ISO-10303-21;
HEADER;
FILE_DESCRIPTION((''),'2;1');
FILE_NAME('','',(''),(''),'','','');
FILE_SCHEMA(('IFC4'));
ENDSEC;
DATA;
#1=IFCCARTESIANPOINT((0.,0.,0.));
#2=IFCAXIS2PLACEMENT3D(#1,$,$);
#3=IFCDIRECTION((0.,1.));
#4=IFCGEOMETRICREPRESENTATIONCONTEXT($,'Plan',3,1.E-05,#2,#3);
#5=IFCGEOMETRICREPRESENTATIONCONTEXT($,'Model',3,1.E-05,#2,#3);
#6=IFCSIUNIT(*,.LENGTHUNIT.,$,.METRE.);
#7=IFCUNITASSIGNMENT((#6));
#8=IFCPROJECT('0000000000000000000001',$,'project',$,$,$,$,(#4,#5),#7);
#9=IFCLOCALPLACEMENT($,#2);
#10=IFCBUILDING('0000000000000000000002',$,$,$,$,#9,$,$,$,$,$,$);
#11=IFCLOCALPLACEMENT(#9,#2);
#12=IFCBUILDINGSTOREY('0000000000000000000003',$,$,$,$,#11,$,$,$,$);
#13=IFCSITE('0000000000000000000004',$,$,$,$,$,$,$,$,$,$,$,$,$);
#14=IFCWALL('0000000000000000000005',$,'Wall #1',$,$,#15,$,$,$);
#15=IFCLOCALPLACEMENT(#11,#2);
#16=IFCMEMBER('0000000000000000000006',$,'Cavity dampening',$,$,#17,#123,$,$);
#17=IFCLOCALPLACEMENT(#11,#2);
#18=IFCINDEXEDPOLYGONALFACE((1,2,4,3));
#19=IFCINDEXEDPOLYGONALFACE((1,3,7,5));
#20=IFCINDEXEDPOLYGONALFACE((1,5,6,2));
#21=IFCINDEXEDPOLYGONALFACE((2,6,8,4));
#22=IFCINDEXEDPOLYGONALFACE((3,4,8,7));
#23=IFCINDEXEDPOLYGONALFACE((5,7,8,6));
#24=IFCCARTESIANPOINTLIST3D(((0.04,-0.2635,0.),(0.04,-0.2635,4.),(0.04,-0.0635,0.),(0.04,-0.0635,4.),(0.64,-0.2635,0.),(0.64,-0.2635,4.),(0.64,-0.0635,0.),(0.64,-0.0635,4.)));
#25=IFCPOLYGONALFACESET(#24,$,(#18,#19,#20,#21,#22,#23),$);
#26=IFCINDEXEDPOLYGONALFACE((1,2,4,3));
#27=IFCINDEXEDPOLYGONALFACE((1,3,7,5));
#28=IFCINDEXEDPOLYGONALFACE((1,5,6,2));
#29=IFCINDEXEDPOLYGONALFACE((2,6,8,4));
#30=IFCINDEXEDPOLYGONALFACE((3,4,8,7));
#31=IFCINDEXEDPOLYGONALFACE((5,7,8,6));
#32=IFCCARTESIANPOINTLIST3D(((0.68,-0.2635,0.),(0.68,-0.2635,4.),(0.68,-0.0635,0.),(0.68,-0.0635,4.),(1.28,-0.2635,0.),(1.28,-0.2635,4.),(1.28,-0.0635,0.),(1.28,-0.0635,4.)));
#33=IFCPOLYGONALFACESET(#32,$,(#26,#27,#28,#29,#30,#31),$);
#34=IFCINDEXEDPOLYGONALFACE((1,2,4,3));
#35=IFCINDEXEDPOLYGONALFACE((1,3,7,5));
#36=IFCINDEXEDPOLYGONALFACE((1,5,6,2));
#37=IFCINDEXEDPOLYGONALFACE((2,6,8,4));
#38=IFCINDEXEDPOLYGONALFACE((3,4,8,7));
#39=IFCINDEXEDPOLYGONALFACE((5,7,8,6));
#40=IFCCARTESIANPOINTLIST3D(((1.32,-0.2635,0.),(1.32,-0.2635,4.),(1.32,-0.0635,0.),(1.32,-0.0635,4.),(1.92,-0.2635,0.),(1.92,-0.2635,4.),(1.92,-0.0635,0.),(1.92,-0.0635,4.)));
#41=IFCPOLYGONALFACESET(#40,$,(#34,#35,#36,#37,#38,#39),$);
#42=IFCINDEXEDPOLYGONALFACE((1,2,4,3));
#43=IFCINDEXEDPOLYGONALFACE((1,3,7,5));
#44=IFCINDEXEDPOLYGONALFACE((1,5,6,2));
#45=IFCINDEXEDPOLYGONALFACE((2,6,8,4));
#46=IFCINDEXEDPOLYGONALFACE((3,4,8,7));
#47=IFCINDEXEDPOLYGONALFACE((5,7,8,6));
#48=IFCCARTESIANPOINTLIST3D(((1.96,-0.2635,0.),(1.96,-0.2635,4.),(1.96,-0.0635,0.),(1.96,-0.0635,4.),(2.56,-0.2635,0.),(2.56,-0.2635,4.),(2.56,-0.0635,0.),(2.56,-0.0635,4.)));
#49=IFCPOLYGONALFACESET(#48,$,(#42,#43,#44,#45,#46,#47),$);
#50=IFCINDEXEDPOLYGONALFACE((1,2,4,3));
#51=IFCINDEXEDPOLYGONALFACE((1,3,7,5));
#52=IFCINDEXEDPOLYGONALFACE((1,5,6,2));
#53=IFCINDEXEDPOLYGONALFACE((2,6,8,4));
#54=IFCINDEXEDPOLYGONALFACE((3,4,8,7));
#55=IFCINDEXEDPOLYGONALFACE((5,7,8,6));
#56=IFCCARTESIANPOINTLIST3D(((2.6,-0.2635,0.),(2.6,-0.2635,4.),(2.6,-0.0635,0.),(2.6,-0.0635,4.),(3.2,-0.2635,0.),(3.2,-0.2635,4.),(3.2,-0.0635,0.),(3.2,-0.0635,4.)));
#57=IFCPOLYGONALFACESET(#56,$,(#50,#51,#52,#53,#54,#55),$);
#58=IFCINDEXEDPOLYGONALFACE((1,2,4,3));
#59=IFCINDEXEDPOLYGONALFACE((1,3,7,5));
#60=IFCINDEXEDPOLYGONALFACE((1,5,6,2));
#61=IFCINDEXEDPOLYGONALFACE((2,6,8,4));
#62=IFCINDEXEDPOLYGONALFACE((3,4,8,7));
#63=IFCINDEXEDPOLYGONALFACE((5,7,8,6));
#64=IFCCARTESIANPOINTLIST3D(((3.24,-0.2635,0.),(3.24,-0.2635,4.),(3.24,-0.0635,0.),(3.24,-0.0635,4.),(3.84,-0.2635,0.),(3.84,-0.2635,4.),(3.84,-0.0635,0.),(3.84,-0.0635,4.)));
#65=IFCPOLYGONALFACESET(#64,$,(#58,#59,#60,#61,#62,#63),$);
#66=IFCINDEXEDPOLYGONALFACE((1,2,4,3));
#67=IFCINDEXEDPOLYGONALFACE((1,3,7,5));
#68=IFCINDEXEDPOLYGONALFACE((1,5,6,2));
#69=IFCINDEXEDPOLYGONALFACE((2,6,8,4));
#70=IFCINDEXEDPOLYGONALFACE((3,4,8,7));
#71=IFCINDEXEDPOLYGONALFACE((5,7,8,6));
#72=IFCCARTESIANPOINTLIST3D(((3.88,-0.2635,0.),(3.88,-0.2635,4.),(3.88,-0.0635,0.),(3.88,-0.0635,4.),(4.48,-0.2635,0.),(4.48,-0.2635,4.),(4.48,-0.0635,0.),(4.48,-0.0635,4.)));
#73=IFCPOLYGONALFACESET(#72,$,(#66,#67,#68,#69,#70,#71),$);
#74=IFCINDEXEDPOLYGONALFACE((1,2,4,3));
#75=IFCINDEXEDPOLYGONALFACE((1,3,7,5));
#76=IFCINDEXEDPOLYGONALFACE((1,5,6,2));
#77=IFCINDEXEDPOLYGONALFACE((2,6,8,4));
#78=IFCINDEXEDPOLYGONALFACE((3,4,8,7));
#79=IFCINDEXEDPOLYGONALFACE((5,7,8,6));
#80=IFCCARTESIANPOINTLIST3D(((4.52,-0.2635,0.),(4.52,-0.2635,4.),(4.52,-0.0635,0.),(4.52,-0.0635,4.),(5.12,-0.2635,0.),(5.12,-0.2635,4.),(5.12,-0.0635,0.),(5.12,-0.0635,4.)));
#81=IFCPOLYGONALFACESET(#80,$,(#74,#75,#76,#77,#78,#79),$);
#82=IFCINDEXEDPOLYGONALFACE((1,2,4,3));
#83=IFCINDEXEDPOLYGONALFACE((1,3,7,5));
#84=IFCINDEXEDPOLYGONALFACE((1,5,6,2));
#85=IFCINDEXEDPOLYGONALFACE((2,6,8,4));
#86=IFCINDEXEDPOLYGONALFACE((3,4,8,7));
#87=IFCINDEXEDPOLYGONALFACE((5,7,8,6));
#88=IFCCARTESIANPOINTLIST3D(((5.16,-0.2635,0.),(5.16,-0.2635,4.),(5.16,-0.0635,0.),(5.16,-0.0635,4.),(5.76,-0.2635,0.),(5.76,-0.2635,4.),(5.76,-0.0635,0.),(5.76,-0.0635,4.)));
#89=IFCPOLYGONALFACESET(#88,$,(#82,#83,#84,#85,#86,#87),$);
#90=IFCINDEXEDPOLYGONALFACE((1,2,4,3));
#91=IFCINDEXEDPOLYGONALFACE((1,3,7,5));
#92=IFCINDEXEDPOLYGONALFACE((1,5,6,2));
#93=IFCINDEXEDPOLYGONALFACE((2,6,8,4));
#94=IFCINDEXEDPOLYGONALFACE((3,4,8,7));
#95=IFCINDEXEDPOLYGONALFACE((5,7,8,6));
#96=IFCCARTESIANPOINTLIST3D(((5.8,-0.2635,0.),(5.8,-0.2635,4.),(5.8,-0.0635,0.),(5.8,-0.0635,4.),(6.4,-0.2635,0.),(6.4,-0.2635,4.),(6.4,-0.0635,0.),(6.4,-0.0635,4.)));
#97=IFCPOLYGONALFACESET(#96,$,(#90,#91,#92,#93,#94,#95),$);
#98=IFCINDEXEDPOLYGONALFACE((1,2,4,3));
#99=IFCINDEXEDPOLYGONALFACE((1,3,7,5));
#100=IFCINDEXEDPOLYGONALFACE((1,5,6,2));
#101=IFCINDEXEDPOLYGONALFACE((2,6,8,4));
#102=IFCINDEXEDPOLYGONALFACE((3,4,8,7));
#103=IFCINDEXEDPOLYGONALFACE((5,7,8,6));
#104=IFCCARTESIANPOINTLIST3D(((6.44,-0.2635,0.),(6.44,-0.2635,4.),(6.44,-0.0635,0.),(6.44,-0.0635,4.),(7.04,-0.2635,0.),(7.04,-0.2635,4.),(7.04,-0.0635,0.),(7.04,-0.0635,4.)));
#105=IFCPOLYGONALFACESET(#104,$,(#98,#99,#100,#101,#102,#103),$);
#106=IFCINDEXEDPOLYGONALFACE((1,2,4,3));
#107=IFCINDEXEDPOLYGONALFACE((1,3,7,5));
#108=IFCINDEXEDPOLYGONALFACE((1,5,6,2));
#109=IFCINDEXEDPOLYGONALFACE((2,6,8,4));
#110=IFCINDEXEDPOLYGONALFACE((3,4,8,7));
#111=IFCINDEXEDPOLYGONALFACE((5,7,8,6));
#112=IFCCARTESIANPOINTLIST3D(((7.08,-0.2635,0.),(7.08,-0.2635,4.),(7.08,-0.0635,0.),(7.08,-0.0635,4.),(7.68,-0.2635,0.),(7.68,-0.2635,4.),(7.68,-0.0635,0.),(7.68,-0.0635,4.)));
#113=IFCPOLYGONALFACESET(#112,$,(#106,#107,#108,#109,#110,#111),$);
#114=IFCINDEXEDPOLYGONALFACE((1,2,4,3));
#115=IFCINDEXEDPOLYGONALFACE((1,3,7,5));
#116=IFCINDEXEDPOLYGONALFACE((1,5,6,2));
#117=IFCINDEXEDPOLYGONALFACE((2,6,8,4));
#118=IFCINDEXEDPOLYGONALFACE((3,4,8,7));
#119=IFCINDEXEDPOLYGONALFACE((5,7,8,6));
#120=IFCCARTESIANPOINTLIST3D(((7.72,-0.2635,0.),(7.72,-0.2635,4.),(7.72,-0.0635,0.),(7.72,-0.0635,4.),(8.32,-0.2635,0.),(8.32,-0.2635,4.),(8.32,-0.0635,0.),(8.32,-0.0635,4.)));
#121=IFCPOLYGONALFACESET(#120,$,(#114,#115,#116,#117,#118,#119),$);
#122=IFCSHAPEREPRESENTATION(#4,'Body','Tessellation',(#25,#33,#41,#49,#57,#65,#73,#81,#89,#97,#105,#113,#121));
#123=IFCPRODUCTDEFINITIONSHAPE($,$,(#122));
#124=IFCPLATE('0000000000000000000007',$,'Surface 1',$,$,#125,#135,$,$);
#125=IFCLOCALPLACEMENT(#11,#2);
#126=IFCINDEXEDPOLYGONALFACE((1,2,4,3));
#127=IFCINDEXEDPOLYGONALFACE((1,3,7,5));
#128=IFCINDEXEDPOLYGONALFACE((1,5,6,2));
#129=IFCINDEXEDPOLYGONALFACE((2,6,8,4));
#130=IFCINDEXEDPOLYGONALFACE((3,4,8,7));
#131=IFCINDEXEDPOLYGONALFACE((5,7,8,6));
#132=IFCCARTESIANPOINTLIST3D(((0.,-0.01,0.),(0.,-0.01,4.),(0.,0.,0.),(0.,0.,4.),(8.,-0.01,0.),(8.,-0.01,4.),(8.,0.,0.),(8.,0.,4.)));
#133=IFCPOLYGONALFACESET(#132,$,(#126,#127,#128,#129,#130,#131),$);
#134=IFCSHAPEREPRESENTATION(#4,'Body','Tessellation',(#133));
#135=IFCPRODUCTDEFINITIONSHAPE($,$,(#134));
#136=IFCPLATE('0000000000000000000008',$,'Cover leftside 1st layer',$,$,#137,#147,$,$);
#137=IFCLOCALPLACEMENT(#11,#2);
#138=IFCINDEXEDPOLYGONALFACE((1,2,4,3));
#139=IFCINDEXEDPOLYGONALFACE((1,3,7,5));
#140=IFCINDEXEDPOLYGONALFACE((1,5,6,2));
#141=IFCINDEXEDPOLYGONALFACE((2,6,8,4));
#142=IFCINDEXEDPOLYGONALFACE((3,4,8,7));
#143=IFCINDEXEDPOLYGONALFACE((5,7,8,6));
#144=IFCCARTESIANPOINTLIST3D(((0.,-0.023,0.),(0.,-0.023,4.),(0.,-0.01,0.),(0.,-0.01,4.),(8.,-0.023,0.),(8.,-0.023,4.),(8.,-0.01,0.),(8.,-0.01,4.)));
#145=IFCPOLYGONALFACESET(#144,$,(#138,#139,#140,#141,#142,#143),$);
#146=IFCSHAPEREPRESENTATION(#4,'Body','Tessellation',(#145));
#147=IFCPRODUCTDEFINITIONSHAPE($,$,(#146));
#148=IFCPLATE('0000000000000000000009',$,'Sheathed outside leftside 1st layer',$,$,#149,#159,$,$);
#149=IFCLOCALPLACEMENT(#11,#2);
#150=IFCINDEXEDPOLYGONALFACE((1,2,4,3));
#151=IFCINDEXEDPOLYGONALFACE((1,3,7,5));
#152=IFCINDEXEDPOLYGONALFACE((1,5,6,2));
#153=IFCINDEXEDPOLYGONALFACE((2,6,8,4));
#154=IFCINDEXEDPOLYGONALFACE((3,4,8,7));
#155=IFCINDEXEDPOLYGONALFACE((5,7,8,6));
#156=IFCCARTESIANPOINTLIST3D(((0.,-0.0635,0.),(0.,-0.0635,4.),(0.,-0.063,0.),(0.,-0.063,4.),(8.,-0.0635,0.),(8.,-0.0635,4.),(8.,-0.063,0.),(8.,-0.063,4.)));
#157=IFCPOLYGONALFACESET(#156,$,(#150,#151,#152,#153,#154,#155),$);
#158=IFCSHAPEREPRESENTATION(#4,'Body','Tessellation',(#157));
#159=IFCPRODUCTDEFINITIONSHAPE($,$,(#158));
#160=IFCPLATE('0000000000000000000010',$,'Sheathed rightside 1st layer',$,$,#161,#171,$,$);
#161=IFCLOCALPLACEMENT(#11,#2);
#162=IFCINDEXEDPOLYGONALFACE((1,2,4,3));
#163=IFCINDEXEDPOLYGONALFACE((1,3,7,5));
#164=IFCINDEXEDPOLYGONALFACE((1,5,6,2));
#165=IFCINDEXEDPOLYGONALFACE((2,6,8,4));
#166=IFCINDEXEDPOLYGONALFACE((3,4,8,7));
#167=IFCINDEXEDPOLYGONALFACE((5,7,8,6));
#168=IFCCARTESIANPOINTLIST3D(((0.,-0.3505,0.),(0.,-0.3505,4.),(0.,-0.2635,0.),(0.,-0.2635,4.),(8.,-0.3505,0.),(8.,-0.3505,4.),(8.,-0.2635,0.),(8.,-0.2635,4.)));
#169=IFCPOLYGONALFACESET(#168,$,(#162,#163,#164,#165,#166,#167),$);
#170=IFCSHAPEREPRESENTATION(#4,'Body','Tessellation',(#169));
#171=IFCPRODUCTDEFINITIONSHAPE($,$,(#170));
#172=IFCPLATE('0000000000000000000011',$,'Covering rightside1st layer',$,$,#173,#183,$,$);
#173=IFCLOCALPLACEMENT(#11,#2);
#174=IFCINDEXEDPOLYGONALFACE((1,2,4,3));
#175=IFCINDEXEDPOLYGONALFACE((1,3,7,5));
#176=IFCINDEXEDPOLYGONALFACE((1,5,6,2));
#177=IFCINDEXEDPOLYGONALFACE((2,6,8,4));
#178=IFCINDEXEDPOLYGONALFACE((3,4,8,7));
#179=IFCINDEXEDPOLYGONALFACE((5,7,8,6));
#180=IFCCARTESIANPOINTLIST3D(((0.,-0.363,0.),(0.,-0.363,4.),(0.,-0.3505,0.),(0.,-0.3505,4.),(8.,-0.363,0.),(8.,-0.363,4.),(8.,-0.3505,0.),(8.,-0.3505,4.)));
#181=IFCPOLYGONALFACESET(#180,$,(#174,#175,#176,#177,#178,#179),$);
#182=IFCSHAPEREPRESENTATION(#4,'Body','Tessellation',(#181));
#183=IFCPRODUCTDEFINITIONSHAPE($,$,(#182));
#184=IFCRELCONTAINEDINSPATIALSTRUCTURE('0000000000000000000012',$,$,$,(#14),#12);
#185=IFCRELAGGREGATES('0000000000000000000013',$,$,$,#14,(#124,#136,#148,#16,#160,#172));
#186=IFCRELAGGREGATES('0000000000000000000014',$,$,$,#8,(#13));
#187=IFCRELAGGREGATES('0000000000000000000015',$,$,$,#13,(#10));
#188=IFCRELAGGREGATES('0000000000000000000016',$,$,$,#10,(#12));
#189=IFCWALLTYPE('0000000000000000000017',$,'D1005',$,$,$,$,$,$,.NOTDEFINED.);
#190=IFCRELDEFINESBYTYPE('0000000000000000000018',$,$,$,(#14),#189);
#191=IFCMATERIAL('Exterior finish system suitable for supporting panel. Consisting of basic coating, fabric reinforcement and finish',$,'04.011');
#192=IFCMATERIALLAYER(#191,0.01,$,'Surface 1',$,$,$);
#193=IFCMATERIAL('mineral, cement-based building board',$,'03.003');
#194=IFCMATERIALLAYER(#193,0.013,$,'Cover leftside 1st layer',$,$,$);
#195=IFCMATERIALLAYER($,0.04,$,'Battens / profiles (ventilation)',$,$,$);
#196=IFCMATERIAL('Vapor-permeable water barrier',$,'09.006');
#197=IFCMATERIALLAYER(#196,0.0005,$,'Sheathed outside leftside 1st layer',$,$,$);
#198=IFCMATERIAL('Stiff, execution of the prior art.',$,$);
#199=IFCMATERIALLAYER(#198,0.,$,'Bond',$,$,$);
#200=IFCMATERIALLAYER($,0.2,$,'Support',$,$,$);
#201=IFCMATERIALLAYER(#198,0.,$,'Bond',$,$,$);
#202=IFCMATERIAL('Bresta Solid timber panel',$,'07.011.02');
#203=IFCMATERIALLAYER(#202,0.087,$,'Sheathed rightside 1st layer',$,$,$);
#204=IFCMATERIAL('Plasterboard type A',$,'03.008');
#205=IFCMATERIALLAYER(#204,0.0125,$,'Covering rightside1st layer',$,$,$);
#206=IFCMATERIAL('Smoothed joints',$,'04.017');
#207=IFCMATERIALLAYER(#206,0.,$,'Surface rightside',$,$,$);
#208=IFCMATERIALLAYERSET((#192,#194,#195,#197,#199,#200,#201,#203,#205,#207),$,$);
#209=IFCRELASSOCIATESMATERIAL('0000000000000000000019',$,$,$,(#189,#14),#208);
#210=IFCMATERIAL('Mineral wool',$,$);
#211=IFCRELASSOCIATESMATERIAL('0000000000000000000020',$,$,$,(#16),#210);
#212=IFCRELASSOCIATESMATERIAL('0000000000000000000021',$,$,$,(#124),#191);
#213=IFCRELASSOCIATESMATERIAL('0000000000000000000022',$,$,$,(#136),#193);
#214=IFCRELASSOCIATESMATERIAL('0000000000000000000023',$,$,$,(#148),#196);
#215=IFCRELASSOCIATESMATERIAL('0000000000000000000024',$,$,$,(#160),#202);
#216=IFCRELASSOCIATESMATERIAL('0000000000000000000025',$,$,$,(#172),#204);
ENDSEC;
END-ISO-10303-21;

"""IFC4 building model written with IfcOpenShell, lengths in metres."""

from ifc_helpers import new_model, si_unit, direction, frame, frame_2d, origin, origin_with_axes, place, context, project, spatial, rectangle, extrude, material, layer, layer_set, type_object, element, aggregate, save


model = new_model("IFC4")

# Units and contexts
plan_context = context("Plan", 3, precision=1e-05, world=origin(), true_north=direction((0.0, 1.0)))
model_context = context("Model", 3, precision=1e-05, world=origin(), true_north=direction((0.0, 1.0)))
ifc_project = project(units=[si_unit("LENGTHUNIT", "METRE")], contexts=[plan_context, model_context])

# Site, building, storey
site = spatial("IfcSite", under=ifc_project)
building_placement = place(None, origin())
building = spatial("IfcBuilding", under=site, at=building_placement)
storey_placement = place(building_placement, origin())
storey = spatial("IfcBuildingStorey", under=building, at=storey_placement)

# Wall, member, plates
ifc_material_1 = material(Name="Exterior finish system suitable for supporting panel. Consisting of basic coating, fabric reinforcement and finish", Category="04.011")
ifc_layer_1 = layer(ifc_material_1, 0.01, Name="Surface 1")
ifc_material_2 = material(Name="mineral, cement-based building board", Category="03.003")
ifc_layer_2 = layer(ifc_material_2, 0.013, Name="Cover leftside 1st layer")
ifc_layer_3 = layer(None, 0.04, Name="Battens / profiles (ventilation)")
ifc_material_3 = material(Name="Vapor-permeable water barrier", Category="09.006")
ifc_layer_4 = layer(ifc_material_3, 0.0005, Name="Sheathed outside leftside 1st layer")
ifc_material_4 = material(Name="Stiff, execution of the prior art.")
ifc_layer_5 = layer(ifc_material_4, 0.0, Name="Bond")
ifc_layer_6 = layer(None, 0.2, Name="Support")
ifc_layer_7 = layer(ifc_material_4, 0.0, Name="Bond")
ifc_material_5 = material(Name="Bresta Solid timber panel", Category="07.011.02")
ifc_layer_8 = layer(ifc_material_5, 0.087, Name="Sheathed rightside 1st layer")
ifc_material_6 = material(Name="Plasterboard type A", Category="03.008")
ifc_layer_9 = layer(ifc_material_6, 0.0125, Name="Covering rightside1st layer")
ifc_material_7 = material(Name="Smoothed joints", Category="04.017")
ifc_layer_10 = layer(ifc_material_7, 0.0, Name="Surface rightside")
ifc_layer_set = layer_set([ifc_layer_1, ifc_layer_2, ifc_layer_3, ifc_layer_4, ifc_layer_5, ifc_layer_6, ifc_layer_7, ifc_layer_8, ifc_layer_9, ifc_layer_10])
wall_type = type_object("IfcWallType", Name="D1005", PredefinedType="NOTDEFINED", material=ifc_layer_set)
wall_placement = place(None, frame((0.0, 0.0, 0.0), z_axis=(0.0, -1.0, 0.0), x_axis=(1.0, 0.0, 0.0)))
wall = element("IfcWall", 1, at=wall_placement, inside=storey, type_object=wall_type, material=ifc_layer_set, Name="Wall #1")
ifc_material_8 = material(Name="Mineral wool")
member_1_placement = place(wall_placement, origin())
member_1 = element("IfcMember", 2, at=member_1_placement, material=ifc_material_8, Name="Cavity dampening", context=plan_context, shape_type="SweptSolid", body=[
    extrude(rectangle(XDim=0.6, YDim=0.2, at=frame_2d((0.3, 0.1), x_axis=(1.0, 0.0))), frame((0.04, 4.0, 0.0635), z_axis=(0.0, -1.0, 0.0), x_axis=(1.0, 0.0, 0.0)), (0.0, 0.0, 1.0), 4.0),
    extrude(rectangle(XDim=0.6, YDim=0.2, at=frame_2d((0.3, 0.1), x_axis=(1.0, 0.0))), frame((0.68, 4.0, 0.0635), z_axis=(0.0, -1.0, 0.0), x_axis=(1.0, 0.0, 0.0)), (0.0, 0.0, 1.0), 4.0),
    extrude(rectangle(XDim=0.6, YDim=0.2, at=frame_2d((0.3, 0.1), x_axis=(1.0, 0.0))), frame((1.32, 4.0, 0.0635), z_axis=(0.0, -1.0, 0.0), x_axis=(1.0, 0.0, 0.0)), (0.0, 0.0, 1.0), 4.0),
    extrude(rectangle(XDim=0.6, YDim=0.2, at=frame_2d((0.3, 0.1), x_axis=(1.0, 0.0))), frame((1.96, 4.0, 0.0635), z_axis=(0.0, -1.0, 0.0), x_axis=(1.0, 0.0, 0.0)), (0.0, 0.0, 1.0), 4.0),
    extrude(rectangle(XDim=0.6, YDim=0.2, at=frame_2d((0.3, 0.1), x_axis=(1.0, 0.0))), frame((2.6, 4.0, 0.0635), z_axis=(0.0, -1.0, 0.0), x_axis=(1.0, 0.0, 0.0)), (0.0, 0.0, 1.0), 4.0),
    extrude(rectangle(XDim=0.6, YDim=0.2, at=frame_2d((0.3, 0.1), x_axis=(1.0, 0.0))), frame((3.24, 4.0, 0.0635), z_axis=(0.0, -1.0, 0.0), x_axis=(1.0, 0.0, 0.0)), (0.0, 0.0, 1.0), 4.0),
    extrude(rectangle(XDim=0.6, YDim=0.2, at=frame_2d((0.3, 0.1), x_axis=(1.0, 0.0))), frame((3.88, 4.0, 0.0635), z_axis=(0.0, -1.0, 0.0), x_axis=(1.0, 0.0, 0.0)), (0.0, 0.0, 1.0), 4.0),
    extrude(rectangle(XDim=0.6, YDim=0.2, at=frame_2d((0.3, 0.1), x_axis=(1.0, 0.0))), frame((4.52, 4.0, 0.0635), z_axis=(0.0, -1.0, 0.0), x_axis=(1.0, 0.0, 0.0)), (0.0, 0.0, 1.0), 4.0),
    extrude(rectangle(XDim=0.6, YDim=0.2, at=frame_2d((0.3, 0.1), x_axis=(1.0, 0.0))), frame((5.16, 4.0, 0.0635), z_axis=(0.0, -1.0, 0.0), x_axis=(1.0, 0.0, 0.0)), (0.0, 0.0, 1.0), 4.0),
    extrude(rectangle(XDim=0.6, YDim=0.2, at=frame_2d((0.3, 0.1), x_axis=(1.0, 0.0))), frame((5.8, 4.0, 0.0635), z_axis=(0.0, -1.0, 0.0), x_axis=(1.0, 0.0, 0.0)), (0.0, 0.0, 1.0), 4.0),
    extrude(rectangle(XDim=0.6, YDim=0.2, at=frame_2d((0.3, 0.1), x_axis=(1.0, 0.0))), frame((6.44, 4.0, 0.0635), z_axis=(0.0, -1.0, 0.0), x_axis=(1.0, 0.0, 0.0)), (0.0, 0.0, 1.0), 4.0),
    extrude(rectangle(XDim=0.6, YDim=0.2, at=frame_2d((0.3, 0.1), x_axis=(1.0, 0.0))), frame((7.08, 4.0, 0.0635), z_axis=(0.0, -1.0, 0.0), x_axis=(1.0, 0.0, 0.0)), (0.0, 0.0, 1.0), 4.0),
    extrude(rectangle(XDim=0.6, YDim=0.2, at=frame_2d((0.3, 0.1), x_axis=(1.0, 0.0))), frame((7.72, 4.0, 0.0635), z_axis=(0.0, -1.0, 0.0), x_axis=(1.0, 0.0, 0.0)), (0.0, 0.0, 1.0), 4.0),
])
plate_1_placement = place(wall_placement, origin())
plate_1 = element("IfcPlate", 3, at=plate_1_placement, material=ifc_material_1, Name="Surface 1", context=plan_context, shape_type="SweptSolid", body=[
    extrude(rectangle(XDim=8.0, YDim=4.0, at=frame_2d((4.0, 2.0), x_axis=(1.0, 0.0))), origin_with_axes(), (0.0, 0.0, 1.0), 0.01),
])
plate_2_placement = place(wall_placement, origin())
plate_2 = element("IfcPlate", 4, at=plate_2_placement, material=ifc_material_2, Name="Cover leftside 1st layer", context=plan_context, shape_type="SweptSolid", body=[
    extrude(rectangle(XDim=8.0, YDim=4.0, at=frame_2d((4.0, 2.0), x_axis=(1.0, 0.0))), frame((0.0, 0.0, 0.01), z_axis=(0.0, 0.0, 1.0), x_axis=(1.0, 0.0, 0.0)), (0.0, 0.0, 1.0), 0.013),
])
plate_3_placement = place(wall_placement, origin())
plate_3 = element("IfcPlate", 5, at=plate_3_placement, material=ifc_material_3, Name="Sheathed outside leftside 1st layer", context=plan_context, shape_type="SweptSolid", body=[
    extrude(rectangle(XDim=8.0, YDim=4.0, at=frame_2d((4.0, 2.0), x_axis=(1.0, 0.0))), frame((0.0, 0.0, 0.063), z_axis=(0.0, 0.0, 1.0), x_axis=(1.0, 0.0, 0.0)), (0.0, 0.0, 1.0), 0.0005),
])
plate_4_placement = place(wall_placement, origin())
plate_4 = element("IfcPlate", 6, at=plate_4_placement, material=ifc_material_5, Name="Sheathed rightside 1st layer", context=plan_context, shape_type="SweptSolid", body=[
    extrude(rectangle(XDim=8.0, YDim=4.0, at=frame_2d((4.0, 2.0), x_axis=(1.0, 0.0))), frame((0.0, 0.0, 0.2635), z_axis=(0.0, 0.0, 1.0), x_axis=(1.0, 0.0, 0.0)), (0.0, 0.0, 1.0), 0.087),
])
plate_5_placement = place(wall_placement, origin())
plate_5 = element("IfcPlate", 7, at=plate_5_placement, material=ifc_material_6, Name="Covering rightside1st layer", context=plan_context, shape_type="SweptSolid", body=[
    extrude(rectangle(XDim=8.0, YDim=4.0, at=frame_2d((4.0, 2.0), x_axis=(1.0, 0.0))), frame((0.0, 0.0, 0.3505), z_axis=(0.0, 0.0, 1.0), x_axis=(1.0, 0.0, 0.0)), (0.0, 0.0, 1.0), 0.0125),
])
aggregate(wall, [plate_1, plate_2, plate_3, member_1, plate_4, plate_5])

save(model, "model.ifc")
